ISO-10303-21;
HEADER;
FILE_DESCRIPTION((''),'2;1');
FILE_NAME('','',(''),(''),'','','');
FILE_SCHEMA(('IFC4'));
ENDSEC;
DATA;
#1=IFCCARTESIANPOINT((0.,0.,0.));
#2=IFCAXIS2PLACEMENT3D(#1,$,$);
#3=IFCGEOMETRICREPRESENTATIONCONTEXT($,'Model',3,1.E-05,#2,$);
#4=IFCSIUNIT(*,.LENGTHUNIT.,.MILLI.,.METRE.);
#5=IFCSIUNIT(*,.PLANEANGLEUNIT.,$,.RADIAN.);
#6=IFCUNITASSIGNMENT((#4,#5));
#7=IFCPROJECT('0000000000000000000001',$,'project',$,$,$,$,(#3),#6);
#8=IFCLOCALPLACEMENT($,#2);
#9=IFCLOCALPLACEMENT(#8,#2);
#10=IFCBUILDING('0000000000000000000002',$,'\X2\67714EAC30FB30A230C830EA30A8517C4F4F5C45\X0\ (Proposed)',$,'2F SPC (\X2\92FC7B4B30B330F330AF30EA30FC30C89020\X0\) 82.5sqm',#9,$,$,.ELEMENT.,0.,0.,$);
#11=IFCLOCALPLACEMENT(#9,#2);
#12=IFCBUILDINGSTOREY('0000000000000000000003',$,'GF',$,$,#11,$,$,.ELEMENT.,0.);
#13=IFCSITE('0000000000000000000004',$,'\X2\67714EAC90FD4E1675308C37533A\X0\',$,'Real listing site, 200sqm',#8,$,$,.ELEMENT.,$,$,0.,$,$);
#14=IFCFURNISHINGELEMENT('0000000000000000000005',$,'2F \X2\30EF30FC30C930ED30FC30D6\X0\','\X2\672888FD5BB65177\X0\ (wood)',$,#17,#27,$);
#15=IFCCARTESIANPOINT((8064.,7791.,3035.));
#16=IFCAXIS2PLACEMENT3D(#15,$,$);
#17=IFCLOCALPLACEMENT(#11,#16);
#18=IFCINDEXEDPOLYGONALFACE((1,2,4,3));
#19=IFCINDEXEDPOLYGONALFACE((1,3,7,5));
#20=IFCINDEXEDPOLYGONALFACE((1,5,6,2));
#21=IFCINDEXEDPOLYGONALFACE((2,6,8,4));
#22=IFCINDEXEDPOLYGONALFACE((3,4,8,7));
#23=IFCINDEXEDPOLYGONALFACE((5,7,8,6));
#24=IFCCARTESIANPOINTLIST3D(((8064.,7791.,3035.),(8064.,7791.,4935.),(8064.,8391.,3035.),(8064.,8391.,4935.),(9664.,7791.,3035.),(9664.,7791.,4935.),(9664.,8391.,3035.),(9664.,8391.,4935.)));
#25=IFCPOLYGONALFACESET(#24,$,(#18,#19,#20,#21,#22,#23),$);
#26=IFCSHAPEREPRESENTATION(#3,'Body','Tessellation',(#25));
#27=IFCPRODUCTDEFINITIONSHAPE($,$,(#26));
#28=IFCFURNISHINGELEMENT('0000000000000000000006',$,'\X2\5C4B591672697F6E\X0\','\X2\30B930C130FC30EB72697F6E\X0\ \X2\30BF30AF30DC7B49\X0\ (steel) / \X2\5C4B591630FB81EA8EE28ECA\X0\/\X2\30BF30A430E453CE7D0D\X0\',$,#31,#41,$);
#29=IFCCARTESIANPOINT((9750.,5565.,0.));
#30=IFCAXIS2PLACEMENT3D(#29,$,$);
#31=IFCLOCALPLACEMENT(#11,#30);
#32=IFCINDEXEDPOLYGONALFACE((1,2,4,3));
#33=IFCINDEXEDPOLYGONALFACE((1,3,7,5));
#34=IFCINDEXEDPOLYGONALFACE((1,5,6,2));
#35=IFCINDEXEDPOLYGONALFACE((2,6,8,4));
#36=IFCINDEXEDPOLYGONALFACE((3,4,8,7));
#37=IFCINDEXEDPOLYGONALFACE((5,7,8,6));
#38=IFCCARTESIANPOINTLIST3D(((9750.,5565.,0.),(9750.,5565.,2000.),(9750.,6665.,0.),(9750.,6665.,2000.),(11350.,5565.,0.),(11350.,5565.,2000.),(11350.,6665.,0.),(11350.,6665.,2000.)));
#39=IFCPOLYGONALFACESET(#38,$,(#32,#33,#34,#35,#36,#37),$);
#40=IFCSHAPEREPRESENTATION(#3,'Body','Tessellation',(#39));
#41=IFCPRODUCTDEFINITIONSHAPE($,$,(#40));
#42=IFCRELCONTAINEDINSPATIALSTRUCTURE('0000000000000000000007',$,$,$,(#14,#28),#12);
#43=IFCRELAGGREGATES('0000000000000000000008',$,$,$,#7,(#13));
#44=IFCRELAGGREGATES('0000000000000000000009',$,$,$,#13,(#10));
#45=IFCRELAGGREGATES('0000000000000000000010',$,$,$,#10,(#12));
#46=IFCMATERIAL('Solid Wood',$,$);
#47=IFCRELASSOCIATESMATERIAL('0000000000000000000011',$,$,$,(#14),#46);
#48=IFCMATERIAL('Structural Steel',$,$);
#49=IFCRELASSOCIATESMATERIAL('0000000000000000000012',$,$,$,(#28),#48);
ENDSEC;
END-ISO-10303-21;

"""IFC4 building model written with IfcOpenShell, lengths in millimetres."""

from ifc_helpers import new_model, si_unit, frame, frame_2d, origin, place, context, project, spatial, rectangle, extrude, material, element, save


model = new_model("IFC4")

# Units and contexts
model_context = context("Model", 3, precision=1e-05, world=origin())
ifc_project = project(units=[si_unit("LENGTHUNIT", "METRE", prefix="MILLI"), si_unit("PLANEANGLEUNIT", "RADIAN")], contexts=[model_context])

# Site, building, storey
site_placement = place(None, origin())
site = spatial("IfcSite", under=ifc_project, at=site_placement, Name="東京都世田谷区", ObjectType="Real listing site, 200sqm", CompositionType="ELEMENT", RefElevation=0.0)
building_placement = place(site_placement, origin())
building = spatial("IfcBuilding", under=site, at=building_placement, Name="東京・アトリエ兼住居 (Proposed)", ObjectType="2F SPC (鋼筋コンクリート造) 82.5sqm", CompositionType="ELEMENT", ElevationOfRefHeight=0.0, ElevationOfTerrain=0.0)
storey_placement = place(building_placement, origin())
storey = spatial("IfcBuildingStorey", under=building, at=storey_placement, Name="GF", CompositionType="ELEMENT", Elevation=0.0)

# Shared definitions
ifc_material_1 = material(Name="Solid Wood")

# Shared definitions
ifc_material_2 = material(Name="Structural Steel")

# Furnishing elements
furnishing_1_placement = place(storey_placement, frame((8064.0, 7791.0, 3035.0)))
element("IfcFurnishingElement", 1, at=furnishing_1_placement, inside=storey, material=ifc_material_1, Name="2F ワードローブ", Description="木製家具 (wood)", context=model_context, shape_type="SweptSolid", body=[
    extrude(rectangle(XDim=1600.0, YDim=600.0, at=frame_2d((800.0, 300.0))), frame((8064.0, 7791.0, 3035.0)), (0.0, 0.0, 1.0), 1900.0),
])
furnishing_2_placement = place(storey_placement, frame((9750.0, 5565.0, 0.0)))
element("IfcFurnishingElement", 2, at=furnishing_2_placement, inside=storey, material=ifc_material_2, Name="屋外物置", Description="スチール物置 タクボ等 (steel) / 屋外・自転車/タイヤ収納", context=model_context, shape_type="SweptSolid", body=[
    extrude(rectangle(XDim=1600.0, YDim=1100.0, at=frame_2d((800.0, 550.0))), frame((9750.0, 5565.0, 0.0)), (0.0, 0.0, 1.0), 2000.0),
])

save(model, "model.ifc")
